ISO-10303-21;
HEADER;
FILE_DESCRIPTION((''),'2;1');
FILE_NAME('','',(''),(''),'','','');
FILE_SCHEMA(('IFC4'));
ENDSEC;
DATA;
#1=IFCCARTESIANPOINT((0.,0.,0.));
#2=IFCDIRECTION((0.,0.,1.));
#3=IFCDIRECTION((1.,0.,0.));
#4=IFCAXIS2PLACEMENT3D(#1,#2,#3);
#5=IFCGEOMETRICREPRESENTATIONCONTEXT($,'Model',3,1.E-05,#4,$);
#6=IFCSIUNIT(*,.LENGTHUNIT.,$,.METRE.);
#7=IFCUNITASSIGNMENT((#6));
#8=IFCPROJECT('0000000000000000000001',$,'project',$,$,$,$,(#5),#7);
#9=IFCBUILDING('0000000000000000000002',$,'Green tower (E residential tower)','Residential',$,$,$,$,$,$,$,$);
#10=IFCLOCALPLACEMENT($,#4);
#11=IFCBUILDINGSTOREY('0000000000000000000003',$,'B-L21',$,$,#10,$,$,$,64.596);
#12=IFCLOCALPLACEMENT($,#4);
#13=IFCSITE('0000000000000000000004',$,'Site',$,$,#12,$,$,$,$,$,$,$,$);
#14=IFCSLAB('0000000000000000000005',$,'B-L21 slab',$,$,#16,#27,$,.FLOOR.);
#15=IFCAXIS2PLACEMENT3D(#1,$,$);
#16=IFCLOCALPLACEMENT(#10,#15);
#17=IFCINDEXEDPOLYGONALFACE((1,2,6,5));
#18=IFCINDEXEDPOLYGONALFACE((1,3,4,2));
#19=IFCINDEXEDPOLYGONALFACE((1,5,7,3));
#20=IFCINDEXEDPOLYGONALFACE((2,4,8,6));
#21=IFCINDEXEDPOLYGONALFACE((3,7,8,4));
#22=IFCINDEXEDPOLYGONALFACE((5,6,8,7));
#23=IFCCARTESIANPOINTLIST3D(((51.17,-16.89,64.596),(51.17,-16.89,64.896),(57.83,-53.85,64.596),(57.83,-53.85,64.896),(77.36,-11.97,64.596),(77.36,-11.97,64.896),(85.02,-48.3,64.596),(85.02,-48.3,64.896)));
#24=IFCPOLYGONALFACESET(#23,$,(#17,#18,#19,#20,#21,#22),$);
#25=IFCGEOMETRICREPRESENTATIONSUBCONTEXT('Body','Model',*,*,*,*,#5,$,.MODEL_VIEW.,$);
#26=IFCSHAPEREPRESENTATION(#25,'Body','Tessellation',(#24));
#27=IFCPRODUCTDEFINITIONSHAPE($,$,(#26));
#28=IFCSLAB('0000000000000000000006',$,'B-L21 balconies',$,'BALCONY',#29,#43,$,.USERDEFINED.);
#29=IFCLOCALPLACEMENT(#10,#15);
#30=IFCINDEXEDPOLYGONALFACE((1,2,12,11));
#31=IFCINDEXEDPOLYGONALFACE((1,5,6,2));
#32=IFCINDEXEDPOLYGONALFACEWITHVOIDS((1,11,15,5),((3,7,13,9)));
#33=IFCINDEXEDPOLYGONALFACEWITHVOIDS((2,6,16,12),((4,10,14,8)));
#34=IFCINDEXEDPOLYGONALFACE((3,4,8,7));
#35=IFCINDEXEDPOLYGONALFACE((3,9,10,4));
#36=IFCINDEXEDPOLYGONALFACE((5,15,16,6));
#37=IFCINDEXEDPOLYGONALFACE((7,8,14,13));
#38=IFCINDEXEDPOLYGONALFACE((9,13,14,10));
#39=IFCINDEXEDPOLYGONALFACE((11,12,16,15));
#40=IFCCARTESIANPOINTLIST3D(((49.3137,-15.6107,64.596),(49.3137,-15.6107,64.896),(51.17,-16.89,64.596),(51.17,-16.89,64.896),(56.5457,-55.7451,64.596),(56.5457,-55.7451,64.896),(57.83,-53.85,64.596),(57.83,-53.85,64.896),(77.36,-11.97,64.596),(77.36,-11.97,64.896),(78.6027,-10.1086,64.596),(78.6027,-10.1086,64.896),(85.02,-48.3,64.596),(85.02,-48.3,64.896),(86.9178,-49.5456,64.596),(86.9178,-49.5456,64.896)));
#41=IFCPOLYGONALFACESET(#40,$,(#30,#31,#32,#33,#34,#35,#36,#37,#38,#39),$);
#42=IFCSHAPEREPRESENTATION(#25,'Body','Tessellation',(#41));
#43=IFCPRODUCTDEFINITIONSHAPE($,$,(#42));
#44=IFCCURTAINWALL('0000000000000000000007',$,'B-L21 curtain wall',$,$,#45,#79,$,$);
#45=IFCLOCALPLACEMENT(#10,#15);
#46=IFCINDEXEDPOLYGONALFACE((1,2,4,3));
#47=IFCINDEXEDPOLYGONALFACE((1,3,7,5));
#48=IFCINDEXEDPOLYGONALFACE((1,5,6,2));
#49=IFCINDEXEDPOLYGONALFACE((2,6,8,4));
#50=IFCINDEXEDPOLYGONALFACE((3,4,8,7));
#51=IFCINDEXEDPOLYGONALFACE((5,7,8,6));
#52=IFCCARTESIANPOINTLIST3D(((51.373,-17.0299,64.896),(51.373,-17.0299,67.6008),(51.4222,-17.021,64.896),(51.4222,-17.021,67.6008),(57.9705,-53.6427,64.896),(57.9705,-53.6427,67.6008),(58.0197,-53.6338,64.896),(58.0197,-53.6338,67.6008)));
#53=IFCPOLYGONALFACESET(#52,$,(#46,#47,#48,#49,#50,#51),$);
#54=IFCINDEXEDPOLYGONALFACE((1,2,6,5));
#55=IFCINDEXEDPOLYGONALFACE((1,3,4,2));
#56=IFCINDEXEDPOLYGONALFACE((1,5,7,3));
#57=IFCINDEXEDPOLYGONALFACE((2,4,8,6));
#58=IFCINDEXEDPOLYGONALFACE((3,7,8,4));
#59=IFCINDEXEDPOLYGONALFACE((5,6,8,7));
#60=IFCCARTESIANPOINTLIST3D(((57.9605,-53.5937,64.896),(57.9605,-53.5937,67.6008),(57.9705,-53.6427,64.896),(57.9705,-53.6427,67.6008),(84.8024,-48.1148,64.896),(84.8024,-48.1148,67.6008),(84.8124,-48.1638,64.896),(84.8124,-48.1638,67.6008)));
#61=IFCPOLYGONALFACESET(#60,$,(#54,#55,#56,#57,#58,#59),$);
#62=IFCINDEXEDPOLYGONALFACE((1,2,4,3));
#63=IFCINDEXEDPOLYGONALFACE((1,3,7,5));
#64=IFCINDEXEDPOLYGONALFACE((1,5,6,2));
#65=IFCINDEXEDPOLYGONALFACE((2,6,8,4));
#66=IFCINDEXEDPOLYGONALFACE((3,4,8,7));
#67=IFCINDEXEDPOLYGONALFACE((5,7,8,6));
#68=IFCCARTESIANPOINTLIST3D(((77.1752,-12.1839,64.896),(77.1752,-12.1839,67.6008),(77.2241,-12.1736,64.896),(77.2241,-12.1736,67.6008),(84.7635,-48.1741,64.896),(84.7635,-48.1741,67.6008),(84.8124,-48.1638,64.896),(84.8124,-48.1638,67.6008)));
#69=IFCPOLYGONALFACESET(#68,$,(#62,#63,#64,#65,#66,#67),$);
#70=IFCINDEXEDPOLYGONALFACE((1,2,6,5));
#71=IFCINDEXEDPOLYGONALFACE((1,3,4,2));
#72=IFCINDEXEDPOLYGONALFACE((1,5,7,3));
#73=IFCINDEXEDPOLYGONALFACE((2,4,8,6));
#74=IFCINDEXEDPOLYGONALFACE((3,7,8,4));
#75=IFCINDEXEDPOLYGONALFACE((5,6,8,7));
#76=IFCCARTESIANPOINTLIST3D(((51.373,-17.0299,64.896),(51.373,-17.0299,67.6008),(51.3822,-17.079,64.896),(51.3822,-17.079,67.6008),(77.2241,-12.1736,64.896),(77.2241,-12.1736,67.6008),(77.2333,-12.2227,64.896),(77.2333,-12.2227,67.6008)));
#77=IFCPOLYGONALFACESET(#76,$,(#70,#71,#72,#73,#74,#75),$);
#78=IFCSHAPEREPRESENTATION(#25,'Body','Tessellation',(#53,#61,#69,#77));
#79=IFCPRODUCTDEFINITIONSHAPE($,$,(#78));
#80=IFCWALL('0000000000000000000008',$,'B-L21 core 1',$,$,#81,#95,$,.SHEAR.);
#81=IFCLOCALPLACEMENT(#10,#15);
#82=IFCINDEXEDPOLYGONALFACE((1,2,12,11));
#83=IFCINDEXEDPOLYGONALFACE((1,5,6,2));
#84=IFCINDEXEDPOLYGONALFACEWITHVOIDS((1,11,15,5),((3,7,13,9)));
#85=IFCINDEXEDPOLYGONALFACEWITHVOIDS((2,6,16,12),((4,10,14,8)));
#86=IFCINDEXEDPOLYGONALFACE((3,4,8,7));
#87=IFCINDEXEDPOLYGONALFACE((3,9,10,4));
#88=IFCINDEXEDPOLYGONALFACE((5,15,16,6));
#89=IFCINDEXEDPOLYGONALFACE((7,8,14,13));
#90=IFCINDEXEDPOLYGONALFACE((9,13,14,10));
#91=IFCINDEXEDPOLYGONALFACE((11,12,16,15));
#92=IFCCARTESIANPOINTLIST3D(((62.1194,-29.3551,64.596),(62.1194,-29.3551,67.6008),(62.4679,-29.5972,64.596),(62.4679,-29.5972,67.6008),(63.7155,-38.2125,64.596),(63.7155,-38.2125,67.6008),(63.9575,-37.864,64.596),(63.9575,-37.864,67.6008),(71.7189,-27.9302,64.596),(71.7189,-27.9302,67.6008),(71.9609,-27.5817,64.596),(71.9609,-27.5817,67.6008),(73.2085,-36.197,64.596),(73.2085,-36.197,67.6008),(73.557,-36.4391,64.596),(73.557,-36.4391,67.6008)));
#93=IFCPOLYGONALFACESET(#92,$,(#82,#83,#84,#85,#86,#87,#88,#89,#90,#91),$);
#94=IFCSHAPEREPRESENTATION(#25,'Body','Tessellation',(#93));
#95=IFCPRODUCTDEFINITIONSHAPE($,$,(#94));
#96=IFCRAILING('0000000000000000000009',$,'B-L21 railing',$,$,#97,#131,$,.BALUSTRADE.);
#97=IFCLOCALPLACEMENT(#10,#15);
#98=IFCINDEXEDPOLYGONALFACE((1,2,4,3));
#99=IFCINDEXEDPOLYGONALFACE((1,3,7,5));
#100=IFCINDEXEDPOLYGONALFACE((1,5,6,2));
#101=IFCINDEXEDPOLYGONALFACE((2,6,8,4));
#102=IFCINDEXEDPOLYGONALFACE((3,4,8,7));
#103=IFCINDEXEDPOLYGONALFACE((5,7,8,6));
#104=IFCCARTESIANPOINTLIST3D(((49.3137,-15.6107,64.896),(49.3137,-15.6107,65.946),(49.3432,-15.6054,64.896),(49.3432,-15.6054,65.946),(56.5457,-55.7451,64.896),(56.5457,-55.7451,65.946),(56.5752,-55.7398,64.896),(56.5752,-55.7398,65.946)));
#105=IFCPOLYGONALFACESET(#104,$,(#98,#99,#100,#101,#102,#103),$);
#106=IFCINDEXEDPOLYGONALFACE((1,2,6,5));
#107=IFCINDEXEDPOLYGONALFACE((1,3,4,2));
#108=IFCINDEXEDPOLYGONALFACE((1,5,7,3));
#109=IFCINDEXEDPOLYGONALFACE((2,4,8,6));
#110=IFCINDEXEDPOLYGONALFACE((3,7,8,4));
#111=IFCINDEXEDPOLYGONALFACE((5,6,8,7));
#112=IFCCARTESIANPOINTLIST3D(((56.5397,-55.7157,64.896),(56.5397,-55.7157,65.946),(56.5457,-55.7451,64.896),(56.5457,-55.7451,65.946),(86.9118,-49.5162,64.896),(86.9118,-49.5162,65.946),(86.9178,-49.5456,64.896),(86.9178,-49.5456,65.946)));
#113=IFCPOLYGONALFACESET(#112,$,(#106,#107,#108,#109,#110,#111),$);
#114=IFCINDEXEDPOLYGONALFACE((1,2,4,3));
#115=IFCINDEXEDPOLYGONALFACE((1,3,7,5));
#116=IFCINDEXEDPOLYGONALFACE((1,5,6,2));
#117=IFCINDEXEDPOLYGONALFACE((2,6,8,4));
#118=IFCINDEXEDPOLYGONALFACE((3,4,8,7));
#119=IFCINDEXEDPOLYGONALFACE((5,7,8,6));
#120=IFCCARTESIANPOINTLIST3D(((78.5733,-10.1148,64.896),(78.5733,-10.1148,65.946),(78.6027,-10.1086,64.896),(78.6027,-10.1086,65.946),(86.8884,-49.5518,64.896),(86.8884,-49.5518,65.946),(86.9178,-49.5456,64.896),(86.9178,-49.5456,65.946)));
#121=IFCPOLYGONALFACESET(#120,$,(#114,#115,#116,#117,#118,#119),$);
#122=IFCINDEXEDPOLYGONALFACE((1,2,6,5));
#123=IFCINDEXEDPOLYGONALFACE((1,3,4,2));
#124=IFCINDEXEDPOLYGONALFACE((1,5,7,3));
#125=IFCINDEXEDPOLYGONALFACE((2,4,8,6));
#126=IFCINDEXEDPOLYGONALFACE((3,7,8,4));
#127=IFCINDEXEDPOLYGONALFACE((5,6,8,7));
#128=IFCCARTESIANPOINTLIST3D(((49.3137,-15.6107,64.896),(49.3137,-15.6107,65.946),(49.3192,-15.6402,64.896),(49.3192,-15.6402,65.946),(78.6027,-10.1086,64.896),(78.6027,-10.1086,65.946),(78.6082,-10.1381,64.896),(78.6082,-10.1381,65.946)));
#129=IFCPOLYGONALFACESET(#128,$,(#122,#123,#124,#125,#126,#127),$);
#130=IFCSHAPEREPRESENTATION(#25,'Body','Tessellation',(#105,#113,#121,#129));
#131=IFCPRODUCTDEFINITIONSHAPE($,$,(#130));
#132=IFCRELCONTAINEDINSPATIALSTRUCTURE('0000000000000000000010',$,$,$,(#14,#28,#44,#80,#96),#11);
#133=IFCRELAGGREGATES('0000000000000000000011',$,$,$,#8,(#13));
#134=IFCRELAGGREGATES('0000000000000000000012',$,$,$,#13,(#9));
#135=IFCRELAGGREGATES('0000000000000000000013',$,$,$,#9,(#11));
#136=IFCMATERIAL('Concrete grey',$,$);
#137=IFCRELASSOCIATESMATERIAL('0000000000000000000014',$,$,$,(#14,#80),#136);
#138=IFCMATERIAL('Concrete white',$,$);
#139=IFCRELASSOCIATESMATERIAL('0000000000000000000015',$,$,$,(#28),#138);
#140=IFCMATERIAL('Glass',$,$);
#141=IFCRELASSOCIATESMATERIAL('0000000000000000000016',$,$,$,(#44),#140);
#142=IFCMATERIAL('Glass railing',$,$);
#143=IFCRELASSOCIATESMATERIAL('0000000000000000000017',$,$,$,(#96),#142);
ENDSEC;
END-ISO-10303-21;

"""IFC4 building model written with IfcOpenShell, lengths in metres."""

from ifc_helpers import new_model, si_unit, frame, origin_with_axes, place, context, subcontext, project, spatial, polyline, outline, extrude, material, element, save


model = new_model("IFC4")

# Units and contexts
model_context = context("Model", 3, precision=1e-05, world=origin_with_axes())
body_context = subcontext(model_context, "Body", "Model", "MODEL_VIEW")
ifc_project = project(units=[si_unit("LENGTHUNIT", "METRE")], contexts=[model_context])

# Site, building, storey
site_placement = place(None, origin_with_axes())
site = spatial("IfcSite", under=ifc_project, at=site_placement, Name="Site")
building = spatial("IfcBuilding", under=site, Name="Green tower (E residential tower)", Description="Residential")
storey_placement = place(None, origin_with_axes())
storey = spatial("IfcBuildingStorey", under=building, at=storey_placement, Name="B-L21", Elevation=64.596)

# Slabs
ifc_material_1 = material(Name="Concrete grey")
slab_1_placement = place(storey_placement, origin_with_axes())
element("IfcSlab", 1, at=slab_1_placement, inside=storey, material=ifc_material_1, Name="B-L21 slab", PredefinedType="FLOOR", context=body_context, shape_type="SweptSolid", body=[
    extrude(outline(polyline([(51.17, -16.89), (57.83, -53.85), (85.02, -48.3), (77.36, -11.97), (51.17, -16.89)])), frame((0.0, 0.0, 64.596), z_axis=(0.0, 0.0, 1.0), x_axis=(1.0, 0.0, 0.0)), (0.0, 0.0, 1.0), 0.3),
])
ifc_material_2 = material(Name="Concrete white")
slab_2_placement = place(storey_placement, origin_with_axes())
element("IfcSlab", 2, at=slab_2_placement, inside=storey, material=ifc_material_2, Name="B-L21 balconies", ObjectType="BALCONY", PredefinedType="USERDEFINED", context=body_context, shape_type="SweptSolid", body=[
    extrude(outline(polyline([(49.3137, -15.6107), (56.5457, -55.7451), (86.9178, -49.5456), (78.6027, -10.1086), (49.3137, -15.6107)]), holes=[polyline([(51.17, -16.89), (57.83, -53.85), (85.02, -48.3), (77.36, -11.97), (51.17, -16.89)])]), frame((0.0, 0.0, 64.596), z_axis=(0.0, 0.0, 1.0), x_axis=(1.0, 0.0, 0.0)), (0.0, 0.0, 1.0), 0.3),
])

# Curtain wall
ifc_material_3 = material(Name="Glass")
curtain_wall_placement = place(storey_placement, origin_with_axes())
element("IfcCurtainWall", 3, at=curtain_wall_placement, inside=storey, material=ifc_material_3, Name="B-L21 curtain wall", context=body_context, shape_type="SweptSolid", body=[
    extrude(outline(polyline([(51.373, -17.0299), (57.9705, -53.6427), (58.0197, -53.6338), (51.4222, -17.021), (51.373, -17.0299)])), frame((0.0, 0.0, 64.896), z_axis=(0.0, 0.0, 1.0), x_axis=(1.0, 0.0, 0.0)), (0.0, 0.0, 1.0), 2.7048),
    extrude(outline(polyline([(57.9705, -53.6427), (84.8124, -48.1638), (84.8024, -48.1148), (57.9605, -53.5937), (57.9705, -53.6427)])), frame((0.0, 0.0, 64.896), z_axis=(0.0, 0.0, 1.0), x_axis=(1.0, 0.0, 0.0)), (0.0, 0.0, 1.0), 2.7048),
    extrude(outline(polyline([(84.8124, -48.1638), (77.2241, -12.1736), (77.1752, -12.1839), (84.7635, -48.1741), (84.8124, -48.1638)])), frame((0.0, 0.0, 64.896), z_axis=(0.0, 0.0, 1.0), x_axis=(1.0, 0.0, 0.0)), (0.0, 0.0, 1.0), 2.7048),
    extrude(outline(polyline([(77.2241, -12.1736), (51.373, -17.0299), (51.3822, -17.079), (77.2333, -12.2227), (77.2241, -12.1736)])), frame((0.0, 0.0, 64.896), z_axis=(0.0, 0.0, 1.0), x_axis=(1.0, 0.0, 0.0)), (0.0, 0.0, 1.0), 2.7048),
])

# Wall
wall_placement = place(storey_placement, origin_with_axes())
element("IfcWall", 4, at=wall_placement, inside=storey, material=ifc_material_1, Name="B-L21 core 1", PredefinedType="SHEAR", context=body_context, shape_type="SweptSolid", body=[
    extrude(outline(polyline([(62.1194, -29.3551), (63.7155, -38.2125), (73.557, -36.4391), (71.9609, -27.5817), (62.1194, -29.3551)]), holes=[polyline([(62.4679, -29.5972), (63.9575, -37.864), (73.2085, -36.197), (71.7189, -27.9302), (62.4679, -29.5972)])]), frame((0.0, 0.0, 64.596), z_axis=(0.0, 0.0, 1.0), x_axis=(1.0, 0.0, 0.0)), (0.0, 0.0, 1.0), 3.0048),
])

# Railing
ifc_material_4 = material(Name="Glass railing")
railing_placement = place(storey_placement, origin_with_axes())
element("IfcRailing", 5, at=railing_placement, inside=storey, material=ifc_material_4, Name="B-L21 railing", PredefinedType="BALUSTRADE", context=body_context, shape_type="SweptSolid", body=[
    extrude(outline(polyline([(49.3137, -15.6107), (56.5457, -55.7451), (56.5752, -55.7398), (49.3432, -15.6054), (49.3137, -15.6107)])), frame((0.0, 0.0, 64.896), z_axis=(0.0, 0.0, 1.0), x_axis=(1.0, 0.0, 0.0)), (0.0, 0.0, 1.0), 1.05),
    extrude(outline(polyline([(56.5457, -55.7451), (86.9178, -49.5456), (86.9118, -49.5162), (56.5397, -55.7157), (56.5457, -55.7451)])), frame((0.0, 0.0, 64.896), z_axis=(0.0, 0.0, 1.0), x_axis=(1.0, 0.0, 0.0)), (0.0, 0.0, 1.0), 1.05),
    extrude(outline(polyline([(86.9178, -49.5456), (78.6027, -10.1086), (78.5733, -10.1148), (86.8884, -49.5518), (86.9178, -49.5456)])), frame((0.0, 0.0, 64.896), z_axis=(0.0, 0.0, 1.0), x_axis=(1.0, 0.0, 0.0)), (0.0, 0.0, 1.0), 1.05),
    extrude(outline(polyline([(78.6027, -10.1086), (49.3137, -15.6107), (49.3192, -15.6402), (78.6082, -10.1381), (78.6027, -10.1086)])), frame((0.0, 0.0, 64.896), z_axis=(0.0, 0.0, 1.0), x_axis=(1.0, 0.0, 0.0)), (0.0, 0.0, 1.0), 1.05),
])

save(model, "model.ifc")
